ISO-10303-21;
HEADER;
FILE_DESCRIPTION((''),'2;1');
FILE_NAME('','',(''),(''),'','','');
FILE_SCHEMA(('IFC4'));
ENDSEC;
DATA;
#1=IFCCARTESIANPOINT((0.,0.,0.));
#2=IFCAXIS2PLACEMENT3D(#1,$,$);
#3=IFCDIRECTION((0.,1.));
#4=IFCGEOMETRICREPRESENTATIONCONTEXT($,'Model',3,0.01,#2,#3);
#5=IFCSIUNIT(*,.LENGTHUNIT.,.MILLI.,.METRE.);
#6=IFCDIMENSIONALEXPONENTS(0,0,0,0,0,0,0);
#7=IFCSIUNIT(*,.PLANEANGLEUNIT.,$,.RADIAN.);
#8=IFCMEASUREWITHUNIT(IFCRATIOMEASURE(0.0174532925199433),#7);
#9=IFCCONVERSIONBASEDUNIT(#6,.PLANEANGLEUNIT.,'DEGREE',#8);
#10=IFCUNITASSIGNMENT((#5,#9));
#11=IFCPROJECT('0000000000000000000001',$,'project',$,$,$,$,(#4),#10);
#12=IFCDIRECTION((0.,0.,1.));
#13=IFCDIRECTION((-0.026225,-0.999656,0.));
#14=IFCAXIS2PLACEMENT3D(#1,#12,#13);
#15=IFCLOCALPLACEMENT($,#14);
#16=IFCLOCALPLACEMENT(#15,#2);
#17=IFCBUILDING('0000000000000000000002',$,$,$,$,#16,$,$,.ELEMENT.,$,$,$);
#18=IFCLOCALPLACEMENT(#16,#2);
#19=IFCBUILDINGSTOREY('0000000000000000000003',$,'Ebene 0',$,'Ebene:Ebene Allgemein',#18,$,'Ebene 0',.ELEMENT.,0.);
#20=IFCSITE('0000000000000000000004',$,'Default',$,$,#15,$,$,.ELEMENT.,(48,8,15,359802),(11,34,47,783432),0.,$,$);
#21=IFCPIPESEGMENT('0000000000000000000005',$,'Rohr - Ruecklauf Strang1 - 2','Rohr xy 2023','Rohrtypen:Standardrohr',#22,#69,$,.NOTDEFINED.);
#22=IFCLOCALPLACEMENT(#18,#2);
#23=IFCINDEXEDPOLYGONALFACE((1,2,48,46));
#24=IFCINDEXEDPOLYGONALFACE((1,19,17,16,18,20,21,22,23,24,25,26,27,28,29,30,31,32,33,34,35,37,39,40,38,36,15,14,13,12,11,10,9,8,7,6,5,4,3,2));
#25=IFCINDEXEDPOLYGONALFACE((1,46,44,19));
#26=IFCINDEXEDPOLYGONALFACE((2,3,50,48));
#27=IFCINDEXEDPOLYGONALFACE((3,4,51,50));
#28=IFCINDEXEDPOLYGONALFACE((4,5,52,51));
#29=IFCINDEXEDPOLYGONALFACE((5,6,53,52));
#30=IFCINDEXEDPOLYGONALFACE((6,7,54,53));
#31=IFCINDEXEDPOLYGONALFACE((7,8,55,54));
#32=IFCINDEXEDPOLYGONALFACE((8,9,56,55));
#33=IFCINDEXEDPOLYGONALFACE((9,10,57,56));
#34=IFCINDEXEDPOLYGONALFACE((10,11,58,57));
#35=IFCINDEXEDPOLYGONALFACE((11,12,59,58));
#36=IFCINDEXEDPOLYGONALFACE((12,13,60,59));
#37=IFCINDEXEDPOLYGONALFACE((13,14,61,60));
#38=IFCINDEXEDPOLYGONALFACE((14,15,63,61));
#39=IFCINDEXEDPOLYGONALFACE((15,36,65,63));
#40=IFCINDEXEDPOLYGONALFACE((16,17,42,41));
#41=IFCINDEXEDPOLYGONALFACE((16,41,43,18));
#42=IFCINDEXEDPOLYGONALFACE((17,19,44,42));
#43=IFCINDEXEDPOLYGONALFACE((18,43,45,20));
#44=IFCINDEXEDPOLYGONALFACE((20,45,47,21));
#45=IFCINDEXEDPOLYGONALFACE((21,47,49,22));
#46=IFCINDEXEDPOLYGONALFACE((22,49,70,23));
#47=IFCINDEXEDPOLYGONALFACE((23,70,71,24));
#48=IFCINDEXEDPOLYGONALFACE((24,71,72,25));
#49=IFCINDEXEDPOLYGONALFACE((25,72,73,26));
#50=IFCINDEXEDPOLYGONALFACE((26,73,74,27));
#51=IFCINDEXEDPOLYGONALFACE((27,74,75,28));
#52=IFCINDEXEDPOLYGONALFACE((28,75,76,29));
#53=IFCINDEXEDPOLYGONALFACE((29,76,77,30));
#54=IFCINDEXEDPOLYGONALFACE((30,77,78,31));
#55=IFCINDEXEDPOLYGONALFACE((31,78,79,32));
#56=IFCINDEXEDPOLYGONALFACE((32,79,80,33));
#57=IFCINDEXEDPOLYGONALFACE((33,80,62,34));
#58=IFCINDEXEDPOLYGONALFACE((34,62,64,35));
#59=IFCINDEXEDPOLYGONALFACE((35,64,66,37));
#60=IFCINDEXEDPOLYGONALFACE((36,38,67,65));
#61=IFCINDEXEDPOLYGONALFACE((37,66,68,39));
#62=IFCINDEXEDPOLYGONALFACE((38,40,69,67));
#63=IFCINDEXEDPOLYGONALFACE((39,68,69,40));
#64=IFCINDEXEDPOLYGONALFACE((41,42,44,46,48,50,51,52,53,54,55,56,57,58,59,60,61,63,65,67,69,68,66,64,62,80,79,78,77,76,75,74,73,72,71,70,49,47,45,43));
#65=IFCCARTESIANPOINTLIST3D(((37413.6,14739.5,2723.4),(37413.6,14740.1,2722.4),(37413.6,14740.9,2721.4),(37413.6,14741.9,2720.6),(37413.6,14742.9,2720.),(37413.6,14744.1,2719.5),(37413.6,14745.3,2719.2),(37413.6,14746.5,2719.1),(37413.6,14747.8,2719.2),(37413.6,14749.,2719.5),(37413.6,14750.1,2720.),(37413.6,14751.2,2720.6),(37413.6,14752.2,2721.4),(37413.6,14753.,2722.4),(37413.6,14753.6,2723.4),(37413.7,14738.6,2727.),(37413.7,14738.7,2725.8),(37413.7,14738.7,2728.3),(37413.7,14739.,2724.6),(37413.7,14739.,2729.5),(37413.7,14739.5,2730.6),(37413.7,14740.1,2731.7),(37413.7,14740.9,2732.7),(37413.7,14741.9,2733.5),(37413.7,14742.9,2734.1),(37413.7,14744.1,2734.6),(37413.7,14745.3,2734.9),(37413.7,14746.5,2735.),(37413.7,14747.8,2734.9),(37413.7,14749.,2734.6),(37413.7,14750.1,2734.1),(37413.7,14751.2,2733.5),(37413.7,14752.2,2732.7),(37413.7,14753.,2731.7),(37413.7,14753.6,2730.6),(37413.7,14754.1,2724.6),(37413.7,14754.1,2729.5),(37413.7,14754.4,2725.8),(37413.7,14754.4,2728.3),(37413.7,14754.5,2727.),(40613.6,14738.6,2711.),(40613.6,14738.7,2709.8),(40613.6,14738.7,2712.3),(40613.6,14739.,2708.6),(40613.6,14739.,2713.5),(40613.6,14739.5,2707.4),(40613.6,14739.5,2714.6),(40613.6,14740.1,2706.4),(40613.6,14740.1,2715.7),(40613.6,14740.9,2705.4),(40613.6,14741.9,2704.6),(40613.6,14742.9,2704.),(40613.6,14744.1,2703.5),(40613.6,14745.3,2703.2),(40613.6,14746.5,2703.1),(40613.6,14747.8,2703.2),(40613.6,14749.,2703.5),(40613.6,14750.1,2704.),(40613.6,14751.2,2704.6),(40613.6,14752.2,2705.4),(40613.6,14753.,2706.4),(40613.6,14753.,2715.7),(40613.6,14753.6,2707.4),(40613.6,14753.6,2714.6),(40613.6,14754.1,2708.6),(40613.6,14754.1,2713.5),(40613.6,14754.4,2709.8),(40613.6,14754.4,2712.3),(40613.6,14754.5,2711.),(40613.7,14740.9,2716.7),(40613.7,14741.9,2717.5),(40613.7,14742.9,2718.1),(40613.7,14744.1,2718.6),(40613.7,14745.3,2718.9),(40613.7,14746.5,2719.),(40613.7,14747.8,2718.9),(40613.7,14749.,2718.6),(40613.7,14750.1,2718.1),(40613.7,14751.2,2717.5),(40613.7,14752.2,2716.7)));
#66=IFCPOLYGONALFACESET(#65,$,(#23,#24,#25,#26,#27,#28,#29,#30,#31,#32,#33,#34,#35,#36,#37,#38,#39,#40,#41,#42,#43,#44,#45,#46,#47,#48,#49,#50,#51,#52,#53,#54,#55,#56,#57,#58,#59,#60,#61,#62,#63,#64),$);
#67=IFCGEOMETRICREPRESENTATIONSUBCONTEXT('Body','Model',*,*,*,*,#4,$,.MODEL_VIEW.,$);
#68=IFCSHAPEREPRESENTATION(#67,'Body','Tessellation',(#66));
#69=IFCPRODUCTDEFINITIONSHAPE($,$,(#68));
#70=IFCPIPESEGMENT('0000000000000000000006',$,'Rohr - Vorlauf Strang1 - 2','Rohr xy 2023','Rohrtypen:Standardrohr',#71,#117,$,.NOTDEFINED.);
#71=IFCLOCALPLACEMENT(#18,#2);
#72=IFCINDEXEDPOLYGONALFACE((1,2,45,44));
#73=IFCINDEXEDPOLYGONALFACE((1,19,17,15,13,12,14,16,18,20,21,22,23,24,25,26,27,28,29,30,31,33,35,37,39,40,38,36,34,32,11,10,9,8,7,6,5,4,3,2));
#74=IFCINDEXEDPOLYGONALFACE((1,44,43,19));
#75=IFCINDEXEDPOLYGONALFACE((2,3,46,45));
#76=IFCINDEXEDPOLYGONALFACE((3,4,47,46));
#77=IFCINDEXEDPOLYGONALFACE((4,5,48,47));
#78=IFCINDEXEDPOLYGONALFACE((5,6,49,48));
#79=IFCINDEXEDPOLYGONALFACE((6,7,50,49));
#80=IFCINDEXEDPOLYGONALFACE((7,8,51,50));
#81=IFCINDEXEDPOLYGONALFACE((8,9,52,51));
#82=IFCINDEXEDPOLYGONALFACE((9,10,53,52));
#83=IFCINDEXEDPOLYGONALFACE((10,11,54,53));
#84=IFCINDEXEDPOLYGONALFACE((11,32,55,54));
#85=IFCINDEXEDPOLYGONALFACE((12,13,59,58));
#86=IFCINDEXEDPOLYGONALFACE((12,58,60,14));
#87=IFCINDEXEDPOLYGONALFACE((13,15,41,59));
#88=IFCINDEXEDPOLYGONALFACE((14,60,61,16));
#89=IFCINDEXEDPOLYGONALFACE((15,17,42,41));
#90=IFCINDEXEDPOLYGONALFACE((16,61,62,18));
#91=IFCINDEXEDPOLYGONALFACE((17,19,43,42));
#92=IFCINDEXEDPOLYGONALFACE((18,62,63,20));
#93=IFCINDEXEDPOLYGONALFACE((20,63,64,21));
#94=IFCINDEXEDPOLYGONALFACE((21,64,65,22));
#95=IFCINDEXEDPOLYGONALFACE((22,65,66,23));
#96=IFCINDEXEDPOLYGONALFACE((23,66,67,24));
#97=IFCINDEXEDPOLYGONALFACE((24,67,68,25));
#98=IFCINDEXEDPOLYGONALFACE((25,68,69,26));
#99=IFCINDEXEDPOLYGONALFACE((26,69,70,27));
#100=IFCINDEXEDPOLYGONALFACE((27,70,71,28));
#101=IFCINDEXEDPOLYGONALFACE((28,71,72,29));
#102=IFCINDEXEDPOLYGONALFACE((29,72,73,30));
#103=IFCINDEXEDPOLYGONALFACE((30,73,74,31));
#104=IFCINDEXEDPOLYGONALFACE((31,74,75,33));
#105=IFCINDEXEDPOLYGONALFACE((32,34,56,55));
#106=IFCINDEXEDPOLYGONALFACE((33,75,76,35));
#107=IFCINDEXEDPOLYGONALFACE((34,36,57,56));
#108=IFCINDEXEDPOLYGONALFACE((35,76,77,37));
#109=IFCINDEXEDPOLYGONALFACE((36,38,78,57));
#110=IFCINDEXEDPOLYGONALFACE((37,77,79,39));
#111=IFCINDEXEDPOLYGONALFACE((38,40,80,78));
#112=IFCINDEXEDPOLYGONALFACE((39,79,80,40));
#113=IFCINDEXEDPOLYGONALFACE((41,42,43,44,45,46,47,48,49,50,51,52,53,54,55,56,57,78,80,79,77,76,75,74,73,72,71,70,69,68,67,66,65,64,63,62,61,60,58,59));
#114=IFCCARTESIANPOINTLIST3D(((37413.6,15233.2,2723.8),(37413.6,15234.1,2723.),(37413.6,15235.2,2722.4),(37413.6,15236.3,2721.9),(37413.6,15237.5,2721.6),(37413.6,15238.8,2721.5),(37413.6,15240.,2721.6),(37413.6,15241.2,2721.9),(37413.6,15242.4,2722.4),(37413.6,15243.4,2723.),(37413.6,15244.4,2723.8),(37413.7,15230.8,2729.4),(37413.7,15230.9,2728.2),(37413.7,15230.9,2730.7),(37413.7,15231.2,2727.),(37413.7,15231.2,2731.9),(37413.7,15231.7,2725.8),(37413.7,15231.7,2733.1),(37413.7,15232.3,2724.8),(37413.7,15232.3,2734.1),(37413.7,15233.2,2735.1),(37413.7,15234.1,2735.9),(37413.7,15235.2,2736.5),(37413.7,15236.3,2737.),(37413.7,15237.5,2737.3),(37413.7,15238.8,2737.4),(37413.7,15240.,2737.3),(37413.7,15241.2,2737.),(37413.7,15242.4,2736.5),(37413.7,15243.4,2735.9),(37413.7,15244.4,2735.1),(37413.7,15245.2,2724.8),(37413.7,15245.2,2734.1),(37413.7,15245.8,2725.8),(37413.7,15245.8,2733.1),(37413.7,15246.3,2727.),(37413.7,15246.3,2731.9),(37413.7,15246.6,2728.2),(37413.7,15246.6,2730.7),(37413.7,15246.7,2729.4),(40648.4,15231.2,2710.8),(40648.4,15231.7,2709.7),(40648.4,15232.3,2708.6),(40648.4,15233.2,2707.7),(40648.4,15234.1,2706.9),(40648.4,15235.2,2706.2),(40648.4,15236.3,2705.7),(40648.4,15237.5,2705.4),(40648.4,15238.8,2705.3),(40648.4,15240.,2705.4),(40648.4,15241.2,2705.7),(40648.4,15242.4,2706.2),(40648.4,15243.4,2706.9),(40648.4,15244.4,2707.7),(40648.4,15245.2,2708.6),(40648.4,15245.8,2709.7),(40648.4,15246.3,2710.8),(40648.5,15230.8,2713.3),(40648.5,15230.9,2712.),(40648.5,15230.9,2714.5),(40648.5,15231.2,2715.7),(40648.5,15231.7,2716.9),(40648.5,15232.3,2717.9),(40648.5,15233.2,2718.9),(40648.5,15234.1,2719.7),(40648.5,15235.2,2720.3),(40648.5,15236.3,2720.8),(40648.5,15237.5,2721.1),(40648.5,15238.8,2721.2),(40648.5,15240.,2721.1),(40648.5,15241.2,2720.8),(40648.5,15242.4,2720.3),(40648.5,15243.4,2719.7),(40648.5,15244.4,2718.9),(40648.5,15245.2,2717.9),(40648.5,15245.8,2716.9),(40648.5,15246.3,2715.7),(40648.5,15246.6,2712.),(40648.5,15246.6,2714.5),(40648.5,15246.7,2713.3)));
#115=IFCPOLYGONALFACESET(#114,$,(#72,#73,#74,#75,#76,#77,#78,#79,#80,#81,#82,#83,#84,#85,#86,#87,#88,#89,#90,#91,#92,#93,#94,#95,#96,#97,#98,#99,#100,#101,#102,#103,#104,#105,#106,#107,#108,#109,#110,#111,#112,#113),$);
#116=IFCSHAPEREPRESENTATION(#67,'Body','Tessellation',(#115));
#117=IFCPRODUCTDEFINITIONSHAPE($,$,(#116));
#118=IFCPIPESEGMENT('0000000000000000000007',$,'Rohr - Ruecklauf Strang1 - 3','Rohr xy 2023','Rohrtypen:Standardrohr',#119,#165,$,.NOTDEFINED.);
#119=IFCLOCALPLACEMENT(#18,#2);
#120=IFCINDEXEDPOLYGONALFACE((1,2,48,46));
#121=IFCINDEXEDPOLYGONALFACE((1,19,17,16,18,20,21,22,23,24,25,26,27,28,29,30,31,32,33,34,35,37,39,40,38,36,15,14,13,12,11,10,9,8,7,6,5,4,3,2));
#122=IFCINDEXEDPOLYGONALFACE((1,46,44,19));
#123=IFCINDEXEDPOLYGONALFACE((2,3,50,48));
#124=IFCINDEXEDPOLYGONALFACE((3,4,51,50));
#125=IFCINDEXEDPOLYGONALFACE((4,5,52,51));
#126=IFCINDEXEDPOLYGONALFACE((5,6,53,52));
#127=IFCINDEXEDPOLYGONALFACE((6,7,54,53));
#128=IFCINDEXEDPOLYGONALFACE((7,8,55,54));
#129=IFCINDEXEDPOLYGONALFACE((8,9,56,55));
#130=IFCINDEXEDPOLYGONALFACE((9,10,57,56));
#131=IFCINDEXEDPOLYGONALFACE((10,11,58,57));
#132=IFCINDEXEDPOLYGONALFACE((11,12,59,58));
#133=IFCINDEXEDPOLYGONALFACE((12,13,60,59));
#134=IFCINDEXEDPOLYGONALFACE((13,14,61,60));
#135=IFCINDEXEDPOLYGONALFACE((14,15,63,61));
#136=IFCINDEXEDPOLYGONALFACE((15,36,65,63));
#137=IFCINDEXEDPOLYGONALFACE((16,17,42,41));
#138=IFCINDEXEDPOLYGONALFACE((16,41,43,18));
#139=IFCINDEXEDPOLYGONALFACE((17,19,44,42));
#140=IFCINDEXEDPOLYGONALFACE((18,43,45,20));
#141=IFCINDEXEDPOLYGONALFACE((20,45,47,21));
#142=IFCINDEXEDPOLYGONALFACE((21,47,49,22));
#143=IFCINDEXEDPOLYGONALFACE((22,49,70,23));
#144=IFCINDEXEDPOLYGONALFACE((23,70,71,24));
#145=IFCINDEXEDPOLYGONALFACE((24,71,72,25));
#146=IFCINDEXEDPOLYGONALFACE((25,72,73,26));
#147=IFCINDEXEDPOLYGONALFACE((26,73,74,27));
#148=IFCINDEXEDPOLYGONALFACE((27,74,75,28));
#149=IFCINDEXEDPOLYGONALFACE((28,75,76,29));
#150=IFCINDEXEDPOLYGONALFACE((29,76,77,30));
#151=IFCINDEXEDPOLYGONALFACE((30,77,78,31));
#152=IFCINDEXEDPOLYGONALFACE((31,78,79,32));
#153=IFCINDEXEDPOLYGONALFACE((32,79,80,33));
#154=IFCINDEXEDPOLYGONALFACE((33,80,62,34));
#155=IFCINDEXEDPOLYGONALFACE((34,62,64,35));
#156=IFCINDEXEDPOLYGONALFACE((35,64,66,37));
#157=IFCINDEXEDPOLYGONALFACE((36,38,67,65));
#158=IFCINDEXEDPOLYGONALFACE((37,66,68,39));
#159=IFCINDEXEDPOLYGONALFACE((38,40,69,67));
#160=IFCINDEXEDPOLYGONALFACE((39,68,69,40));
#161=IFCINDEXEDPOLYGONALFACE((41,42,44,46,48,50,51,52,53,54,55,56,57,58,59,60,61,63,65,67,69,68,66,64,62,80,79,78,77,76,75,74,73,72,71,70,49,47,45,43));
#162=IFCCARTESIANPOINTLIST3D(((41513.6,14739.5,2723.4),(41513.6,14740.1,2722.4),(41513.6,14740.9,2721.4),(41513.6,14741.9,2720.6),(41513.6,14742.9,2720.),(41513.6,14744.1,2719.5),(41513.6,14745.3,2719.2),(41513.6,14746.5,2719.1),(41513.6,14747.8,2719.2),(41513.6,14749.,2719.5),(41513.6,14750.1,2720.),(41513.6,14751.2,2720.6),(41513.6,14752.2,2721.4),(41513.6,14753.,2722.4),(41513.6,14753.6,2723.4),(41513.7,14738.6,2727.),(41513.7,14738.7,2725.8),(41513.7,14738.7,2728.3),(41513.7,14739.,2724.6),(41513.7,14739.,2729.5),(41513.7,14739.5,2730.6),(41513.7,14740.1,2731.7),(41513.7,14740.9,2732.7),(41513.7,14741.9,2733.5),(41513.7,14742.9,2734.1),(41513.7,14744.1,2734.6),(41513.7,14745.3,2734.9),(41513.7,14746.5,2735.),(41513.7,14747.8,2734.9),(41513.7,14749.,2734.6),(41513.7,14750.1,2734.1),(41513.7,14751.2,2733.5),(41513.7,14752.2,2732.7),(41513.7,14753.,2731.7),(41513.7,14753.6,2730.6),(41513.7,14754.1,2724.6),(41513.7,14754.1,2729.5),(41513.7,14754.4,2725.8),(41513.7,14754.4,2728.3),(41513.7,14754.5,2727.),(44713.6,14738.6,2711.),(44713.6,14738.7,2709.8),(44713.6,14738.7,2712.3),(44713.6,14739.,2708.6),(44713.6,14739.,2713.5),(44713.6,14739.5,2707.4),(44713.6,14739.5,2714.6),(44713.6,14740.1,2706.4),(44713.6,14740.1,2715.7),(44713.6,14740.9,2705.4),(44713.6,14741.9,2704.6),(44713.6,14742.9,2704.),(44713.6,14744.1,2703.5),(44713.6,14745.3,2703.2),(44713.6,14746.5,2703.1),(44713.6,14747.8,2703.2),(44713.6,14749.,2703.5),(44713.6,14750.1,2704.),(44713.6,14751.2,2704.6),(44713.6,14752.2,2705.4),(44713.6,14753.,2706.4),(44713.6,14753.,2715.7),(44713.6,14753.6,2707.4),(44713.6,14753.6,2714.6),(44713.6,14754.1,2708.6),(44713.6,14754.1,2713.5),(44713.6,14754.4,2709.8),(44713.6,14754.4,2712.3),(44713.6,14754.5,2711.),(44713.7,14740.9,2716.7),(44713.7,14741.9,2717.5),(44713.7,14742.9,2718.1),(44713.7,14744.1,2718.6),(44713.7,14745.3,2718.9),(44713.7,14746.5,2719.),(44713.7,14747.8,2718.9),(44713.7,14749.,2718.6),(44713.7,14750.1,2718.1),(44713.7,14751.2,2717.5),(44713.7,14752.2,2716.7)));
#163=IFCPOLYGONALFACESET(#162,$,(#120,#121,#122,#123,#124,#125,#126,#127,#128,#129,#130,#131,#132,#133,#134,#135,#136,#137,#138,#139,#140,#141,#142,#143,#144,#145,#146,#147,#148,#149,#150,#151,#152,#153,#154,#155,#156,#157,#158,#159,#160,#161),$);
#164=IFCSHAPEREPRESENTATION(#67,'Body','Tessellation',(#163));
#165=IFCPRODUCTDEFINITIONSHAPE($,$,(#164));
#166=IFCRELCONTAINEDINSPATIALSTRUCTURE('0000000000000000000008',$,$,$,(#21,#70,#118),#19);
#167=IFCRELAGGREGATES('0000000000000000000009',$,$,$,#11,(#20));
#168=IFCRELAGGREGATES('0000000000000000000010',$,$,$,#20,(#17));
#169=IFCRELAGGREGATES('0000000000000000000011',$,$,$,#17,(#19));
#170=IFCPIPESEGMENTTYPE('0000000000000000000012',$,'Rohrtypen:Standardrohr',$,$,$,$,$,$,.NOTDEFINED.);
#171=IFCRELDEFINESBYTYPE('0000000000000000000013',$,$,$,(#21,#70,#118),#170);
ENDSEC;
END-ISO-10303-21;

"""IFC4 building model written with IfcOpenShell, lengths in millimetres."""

from ifc_helpers import new_model, entity, si_unit, converted_unit, direction, frame, origin, place, context, subcontext, project, spatial, indexed_curve, outline, extrude, type_object, element, save


model = new_model("IFC4")

# Units and contexts
model_context = context("Model", 3, precision=0.01, world=origin(), true_north=direction((0.0, 1.0)))
body_context = subcontext(model_context, "Body", "Model", "MODEL_VIEW")
ifc_project = project(units=[si_unit("LENGTHUNIT", "METRE", prefix="MILLI"), converted_unit("PLANEANGLEUNIT", "DEGREE", entity("IfcRatioMeasure", 0.0174532925199433), si_unit("PLANEANGLEUNIT", "RADIAN"), dimensions=[0, 0, 0, 0, 0, 0, 0])], contexts=[model_context])

# Site, building, storey
site_placement = place(None, frame((0.0, 0.0, 0.0), z_axis=(0.0, 0.0, 1.0), x_axis=(-0.026225, -0.999656, 0.0)))
site = spatial("IfcSite", under=ifc_project, at=site_placement, Name="Default", CompositionType="ELEMENT", RefLatitude=(48, 8, 15, 359802), RefLongitude=(11, 34, 47, 783432), RefElevation=0.0)
building_placement = place(site_placement, origin())
building = spatial("IfcBuilding", under=site, at=building_placement, CompositionType="ELEMENT")
storey_placement = place(building_placement, origin())
storey = spatial("IfcBuildingStorey", under=building, at=storey_placement, Name="Ebene 0", ObjectType="Ebene:Ebene Allgemein", LongName="Ebene 0", CompositionType="ELEMENT", Elevation=0.0)

# Pipe segments
pipe_segment_type = type_object("IfcPipeSegmentType", Name="Rohrtypen:Standardrohr", PredefinedType="NOTDEFINED")
pipe_segment_1_placement = place(storey_placement, origin())
element("IfcPipeSegment", 1, at=pipe_segment_1_placement, inside=storey, type_object=pipe_segment_type, Name="Rohr - Ruecklauf Strang1 - 2", Description="Rohr xy 2023", ObjectType="Rohrtypen:Standardrohr", PredefinedType="NOTDEFINED", context=body_context, shape_type="SweptSolid", body=[
    extrude(outline(indexed_curve([(7.9, 0.0), (7.8, 1.2), (7.6, 2.5), (7.1, 3.6), (6.4, 4.7), (5.6, 5.6), (4.7, 6.4), (3.6, 7.1), (2.5, 7.6), (1.2, 7.8), (0.0, 7.9), (-1.2, 7.8), (-2.5, 7.6), (-3.6, 7.1), (-4.7, 6.4), (-5.6, 5.6), (-6.4, 4.7), (-7.1, 3.6), (-7.6, 2.5), (-7.8, 1.2), (-7.9, 0.0), (-7.8, -1.2), (-7.6, -2.5), (-7.1, -3.6), (-6.4, -4.7), (-5.6, -5.6), (-4.7, -6.4), (-3.6, -7.1), (-2.5, -7.6), (-1.2, -7.8), (0.0, -7.9), (1.2, -7.8), (2.5, -7.6), (3.6, -7.1), (4.7, -6.4), (5.6, -5.6), (6.4, -4.7), (7.1, -3.6), (7.6, -2.5), (7.8, -1.2), (7.9, 0.0)], self_intersect=False)), frame((40613.6, 14746.5, 2711.0), z_axis=(-0.999988, 0.0, 0.005), x_axis=(0.0, 1.0, 0.0)), (0.0, 0.0, 1.0), 3200.0),
])
pipe_segment_2_placement = place(storey_placement, origin())
element("IfcPipeSegment", 2, at=pipe_segment_2_placement, inside=storey, type_object=pipe_segment_type, Name="Rohr - Vorlauf Strang1 - 2", Description="Rohr xy 2023", ObjectType="Rohrtypen:Standardrohr", PredefinedType="NOTDEFINED", context=body_context, shape_type="SweptSolid", body=[
    extrude(outline(indexed_curve([(7.9, 0.0), (7.8, 1.2), (7.6, 2.5), (7.1, 3.6), (6.4, 4.7), (5.6, 5.6), (4.7, 6.4), (3.6, 7.1), (2.5, 7.6), (1.2, 7.8), (0.0, 7.9), (-1.2, 7.8), (-2.5, 7.6), (-3.6, 7.1), (-4.7, 6.4), (-5.6, 5.6), (-6.4, 4.7), (-7.1, 3.6), (-7.6, 2.5), (-7.8, 1.2), (-7.9, 0.0), (-7.8, -1.2), (-7.6, -2.5), (-7.1, -3.6), (-6.4, -4.7), (-5.6, -5.6), (-4.7, -6.4), (-3.6, -7.1), (-2.5, -7.6), (-1.2, -7.8), (0.0, -7.9), (1.2, -7.8), (2.5, -7.6), (3.6, -7.1), (4.7, -6.4), (5.6, -5.6), (6.4, -4.7), (7.1, -3.6), (7.6, -2.5), (7.8, -1.2), (7.9, 0.0)], self_intersect=False)), frame((40648.5, 15238.8, 2713.3), z_axis=(-0.999988, 0.0, 0.005), x_axis=(0.0, 1.0, 0.0)), (0.0, 0.0, 1.0), 3234.8),
])
pipe_segment_3_placement = place(storey_placement, origin())
element("IfcPipeSegment", 3, at=pipe_segment_3_placement, inside=storey, type_object=pipe_segment_type, Name="Rohr - Ruecklauf Strang1 - 3", Description="Rohr xy 2023", ObjectType="Rohrtypen:Standardrohr", PredefinedType="NOTDEFINED", context=body_context, shape_type="SweptSolid", body=[
    extrude(outline(indexed_curve([(7.9, 0.0), (7.8, 1.2), (7.6, 2.5), (7.1, 3.6), (6.4, 4.7), (5.6, 5.6), (4.7, 6.4), (3.6, 7.1), (2.5, 7.6), (1.2, 7.8), (0.0, 7.9), (-1.2, 7.8), (-2.5, 7.6), (-3.6, 7.1), (-4.7, 6.4), (-5.6, 5.6), (-6.4, 4.7), (-7.1, 3.6), (-7.6, 2.5), (-7.8, 1.2), (-7.9, 0.0), (-7.8, -1.2), (-7.6, -2.5), (-7.1, -3.6), (-6.4, -4.7), (-5.6, -5.6), (-4.7, -6.4), (-3.6, -7.1), (-2.5, -7.6), (-1.2, -7.8), (0.0, -7.9), (1.2, -7.8), (2.5, -7.6), (3.6, -7.1), (4.7, -6.4), (5.6, -5.6), (6.4, -4.7), (7.1, -3.6), (7.6, -2.5), (7.8, -1.2), (7.9, 0.0)], self_intersect=False)), frame((44713.6, 14746.5, 2711.0), z_axis=(-0.999988, 0.0, 0.005), x_axis=(0.0, 1.0, 0.0)), (0.0, 0.0, 1.0), 3200.0),
])

save(model, "model.ifc")
